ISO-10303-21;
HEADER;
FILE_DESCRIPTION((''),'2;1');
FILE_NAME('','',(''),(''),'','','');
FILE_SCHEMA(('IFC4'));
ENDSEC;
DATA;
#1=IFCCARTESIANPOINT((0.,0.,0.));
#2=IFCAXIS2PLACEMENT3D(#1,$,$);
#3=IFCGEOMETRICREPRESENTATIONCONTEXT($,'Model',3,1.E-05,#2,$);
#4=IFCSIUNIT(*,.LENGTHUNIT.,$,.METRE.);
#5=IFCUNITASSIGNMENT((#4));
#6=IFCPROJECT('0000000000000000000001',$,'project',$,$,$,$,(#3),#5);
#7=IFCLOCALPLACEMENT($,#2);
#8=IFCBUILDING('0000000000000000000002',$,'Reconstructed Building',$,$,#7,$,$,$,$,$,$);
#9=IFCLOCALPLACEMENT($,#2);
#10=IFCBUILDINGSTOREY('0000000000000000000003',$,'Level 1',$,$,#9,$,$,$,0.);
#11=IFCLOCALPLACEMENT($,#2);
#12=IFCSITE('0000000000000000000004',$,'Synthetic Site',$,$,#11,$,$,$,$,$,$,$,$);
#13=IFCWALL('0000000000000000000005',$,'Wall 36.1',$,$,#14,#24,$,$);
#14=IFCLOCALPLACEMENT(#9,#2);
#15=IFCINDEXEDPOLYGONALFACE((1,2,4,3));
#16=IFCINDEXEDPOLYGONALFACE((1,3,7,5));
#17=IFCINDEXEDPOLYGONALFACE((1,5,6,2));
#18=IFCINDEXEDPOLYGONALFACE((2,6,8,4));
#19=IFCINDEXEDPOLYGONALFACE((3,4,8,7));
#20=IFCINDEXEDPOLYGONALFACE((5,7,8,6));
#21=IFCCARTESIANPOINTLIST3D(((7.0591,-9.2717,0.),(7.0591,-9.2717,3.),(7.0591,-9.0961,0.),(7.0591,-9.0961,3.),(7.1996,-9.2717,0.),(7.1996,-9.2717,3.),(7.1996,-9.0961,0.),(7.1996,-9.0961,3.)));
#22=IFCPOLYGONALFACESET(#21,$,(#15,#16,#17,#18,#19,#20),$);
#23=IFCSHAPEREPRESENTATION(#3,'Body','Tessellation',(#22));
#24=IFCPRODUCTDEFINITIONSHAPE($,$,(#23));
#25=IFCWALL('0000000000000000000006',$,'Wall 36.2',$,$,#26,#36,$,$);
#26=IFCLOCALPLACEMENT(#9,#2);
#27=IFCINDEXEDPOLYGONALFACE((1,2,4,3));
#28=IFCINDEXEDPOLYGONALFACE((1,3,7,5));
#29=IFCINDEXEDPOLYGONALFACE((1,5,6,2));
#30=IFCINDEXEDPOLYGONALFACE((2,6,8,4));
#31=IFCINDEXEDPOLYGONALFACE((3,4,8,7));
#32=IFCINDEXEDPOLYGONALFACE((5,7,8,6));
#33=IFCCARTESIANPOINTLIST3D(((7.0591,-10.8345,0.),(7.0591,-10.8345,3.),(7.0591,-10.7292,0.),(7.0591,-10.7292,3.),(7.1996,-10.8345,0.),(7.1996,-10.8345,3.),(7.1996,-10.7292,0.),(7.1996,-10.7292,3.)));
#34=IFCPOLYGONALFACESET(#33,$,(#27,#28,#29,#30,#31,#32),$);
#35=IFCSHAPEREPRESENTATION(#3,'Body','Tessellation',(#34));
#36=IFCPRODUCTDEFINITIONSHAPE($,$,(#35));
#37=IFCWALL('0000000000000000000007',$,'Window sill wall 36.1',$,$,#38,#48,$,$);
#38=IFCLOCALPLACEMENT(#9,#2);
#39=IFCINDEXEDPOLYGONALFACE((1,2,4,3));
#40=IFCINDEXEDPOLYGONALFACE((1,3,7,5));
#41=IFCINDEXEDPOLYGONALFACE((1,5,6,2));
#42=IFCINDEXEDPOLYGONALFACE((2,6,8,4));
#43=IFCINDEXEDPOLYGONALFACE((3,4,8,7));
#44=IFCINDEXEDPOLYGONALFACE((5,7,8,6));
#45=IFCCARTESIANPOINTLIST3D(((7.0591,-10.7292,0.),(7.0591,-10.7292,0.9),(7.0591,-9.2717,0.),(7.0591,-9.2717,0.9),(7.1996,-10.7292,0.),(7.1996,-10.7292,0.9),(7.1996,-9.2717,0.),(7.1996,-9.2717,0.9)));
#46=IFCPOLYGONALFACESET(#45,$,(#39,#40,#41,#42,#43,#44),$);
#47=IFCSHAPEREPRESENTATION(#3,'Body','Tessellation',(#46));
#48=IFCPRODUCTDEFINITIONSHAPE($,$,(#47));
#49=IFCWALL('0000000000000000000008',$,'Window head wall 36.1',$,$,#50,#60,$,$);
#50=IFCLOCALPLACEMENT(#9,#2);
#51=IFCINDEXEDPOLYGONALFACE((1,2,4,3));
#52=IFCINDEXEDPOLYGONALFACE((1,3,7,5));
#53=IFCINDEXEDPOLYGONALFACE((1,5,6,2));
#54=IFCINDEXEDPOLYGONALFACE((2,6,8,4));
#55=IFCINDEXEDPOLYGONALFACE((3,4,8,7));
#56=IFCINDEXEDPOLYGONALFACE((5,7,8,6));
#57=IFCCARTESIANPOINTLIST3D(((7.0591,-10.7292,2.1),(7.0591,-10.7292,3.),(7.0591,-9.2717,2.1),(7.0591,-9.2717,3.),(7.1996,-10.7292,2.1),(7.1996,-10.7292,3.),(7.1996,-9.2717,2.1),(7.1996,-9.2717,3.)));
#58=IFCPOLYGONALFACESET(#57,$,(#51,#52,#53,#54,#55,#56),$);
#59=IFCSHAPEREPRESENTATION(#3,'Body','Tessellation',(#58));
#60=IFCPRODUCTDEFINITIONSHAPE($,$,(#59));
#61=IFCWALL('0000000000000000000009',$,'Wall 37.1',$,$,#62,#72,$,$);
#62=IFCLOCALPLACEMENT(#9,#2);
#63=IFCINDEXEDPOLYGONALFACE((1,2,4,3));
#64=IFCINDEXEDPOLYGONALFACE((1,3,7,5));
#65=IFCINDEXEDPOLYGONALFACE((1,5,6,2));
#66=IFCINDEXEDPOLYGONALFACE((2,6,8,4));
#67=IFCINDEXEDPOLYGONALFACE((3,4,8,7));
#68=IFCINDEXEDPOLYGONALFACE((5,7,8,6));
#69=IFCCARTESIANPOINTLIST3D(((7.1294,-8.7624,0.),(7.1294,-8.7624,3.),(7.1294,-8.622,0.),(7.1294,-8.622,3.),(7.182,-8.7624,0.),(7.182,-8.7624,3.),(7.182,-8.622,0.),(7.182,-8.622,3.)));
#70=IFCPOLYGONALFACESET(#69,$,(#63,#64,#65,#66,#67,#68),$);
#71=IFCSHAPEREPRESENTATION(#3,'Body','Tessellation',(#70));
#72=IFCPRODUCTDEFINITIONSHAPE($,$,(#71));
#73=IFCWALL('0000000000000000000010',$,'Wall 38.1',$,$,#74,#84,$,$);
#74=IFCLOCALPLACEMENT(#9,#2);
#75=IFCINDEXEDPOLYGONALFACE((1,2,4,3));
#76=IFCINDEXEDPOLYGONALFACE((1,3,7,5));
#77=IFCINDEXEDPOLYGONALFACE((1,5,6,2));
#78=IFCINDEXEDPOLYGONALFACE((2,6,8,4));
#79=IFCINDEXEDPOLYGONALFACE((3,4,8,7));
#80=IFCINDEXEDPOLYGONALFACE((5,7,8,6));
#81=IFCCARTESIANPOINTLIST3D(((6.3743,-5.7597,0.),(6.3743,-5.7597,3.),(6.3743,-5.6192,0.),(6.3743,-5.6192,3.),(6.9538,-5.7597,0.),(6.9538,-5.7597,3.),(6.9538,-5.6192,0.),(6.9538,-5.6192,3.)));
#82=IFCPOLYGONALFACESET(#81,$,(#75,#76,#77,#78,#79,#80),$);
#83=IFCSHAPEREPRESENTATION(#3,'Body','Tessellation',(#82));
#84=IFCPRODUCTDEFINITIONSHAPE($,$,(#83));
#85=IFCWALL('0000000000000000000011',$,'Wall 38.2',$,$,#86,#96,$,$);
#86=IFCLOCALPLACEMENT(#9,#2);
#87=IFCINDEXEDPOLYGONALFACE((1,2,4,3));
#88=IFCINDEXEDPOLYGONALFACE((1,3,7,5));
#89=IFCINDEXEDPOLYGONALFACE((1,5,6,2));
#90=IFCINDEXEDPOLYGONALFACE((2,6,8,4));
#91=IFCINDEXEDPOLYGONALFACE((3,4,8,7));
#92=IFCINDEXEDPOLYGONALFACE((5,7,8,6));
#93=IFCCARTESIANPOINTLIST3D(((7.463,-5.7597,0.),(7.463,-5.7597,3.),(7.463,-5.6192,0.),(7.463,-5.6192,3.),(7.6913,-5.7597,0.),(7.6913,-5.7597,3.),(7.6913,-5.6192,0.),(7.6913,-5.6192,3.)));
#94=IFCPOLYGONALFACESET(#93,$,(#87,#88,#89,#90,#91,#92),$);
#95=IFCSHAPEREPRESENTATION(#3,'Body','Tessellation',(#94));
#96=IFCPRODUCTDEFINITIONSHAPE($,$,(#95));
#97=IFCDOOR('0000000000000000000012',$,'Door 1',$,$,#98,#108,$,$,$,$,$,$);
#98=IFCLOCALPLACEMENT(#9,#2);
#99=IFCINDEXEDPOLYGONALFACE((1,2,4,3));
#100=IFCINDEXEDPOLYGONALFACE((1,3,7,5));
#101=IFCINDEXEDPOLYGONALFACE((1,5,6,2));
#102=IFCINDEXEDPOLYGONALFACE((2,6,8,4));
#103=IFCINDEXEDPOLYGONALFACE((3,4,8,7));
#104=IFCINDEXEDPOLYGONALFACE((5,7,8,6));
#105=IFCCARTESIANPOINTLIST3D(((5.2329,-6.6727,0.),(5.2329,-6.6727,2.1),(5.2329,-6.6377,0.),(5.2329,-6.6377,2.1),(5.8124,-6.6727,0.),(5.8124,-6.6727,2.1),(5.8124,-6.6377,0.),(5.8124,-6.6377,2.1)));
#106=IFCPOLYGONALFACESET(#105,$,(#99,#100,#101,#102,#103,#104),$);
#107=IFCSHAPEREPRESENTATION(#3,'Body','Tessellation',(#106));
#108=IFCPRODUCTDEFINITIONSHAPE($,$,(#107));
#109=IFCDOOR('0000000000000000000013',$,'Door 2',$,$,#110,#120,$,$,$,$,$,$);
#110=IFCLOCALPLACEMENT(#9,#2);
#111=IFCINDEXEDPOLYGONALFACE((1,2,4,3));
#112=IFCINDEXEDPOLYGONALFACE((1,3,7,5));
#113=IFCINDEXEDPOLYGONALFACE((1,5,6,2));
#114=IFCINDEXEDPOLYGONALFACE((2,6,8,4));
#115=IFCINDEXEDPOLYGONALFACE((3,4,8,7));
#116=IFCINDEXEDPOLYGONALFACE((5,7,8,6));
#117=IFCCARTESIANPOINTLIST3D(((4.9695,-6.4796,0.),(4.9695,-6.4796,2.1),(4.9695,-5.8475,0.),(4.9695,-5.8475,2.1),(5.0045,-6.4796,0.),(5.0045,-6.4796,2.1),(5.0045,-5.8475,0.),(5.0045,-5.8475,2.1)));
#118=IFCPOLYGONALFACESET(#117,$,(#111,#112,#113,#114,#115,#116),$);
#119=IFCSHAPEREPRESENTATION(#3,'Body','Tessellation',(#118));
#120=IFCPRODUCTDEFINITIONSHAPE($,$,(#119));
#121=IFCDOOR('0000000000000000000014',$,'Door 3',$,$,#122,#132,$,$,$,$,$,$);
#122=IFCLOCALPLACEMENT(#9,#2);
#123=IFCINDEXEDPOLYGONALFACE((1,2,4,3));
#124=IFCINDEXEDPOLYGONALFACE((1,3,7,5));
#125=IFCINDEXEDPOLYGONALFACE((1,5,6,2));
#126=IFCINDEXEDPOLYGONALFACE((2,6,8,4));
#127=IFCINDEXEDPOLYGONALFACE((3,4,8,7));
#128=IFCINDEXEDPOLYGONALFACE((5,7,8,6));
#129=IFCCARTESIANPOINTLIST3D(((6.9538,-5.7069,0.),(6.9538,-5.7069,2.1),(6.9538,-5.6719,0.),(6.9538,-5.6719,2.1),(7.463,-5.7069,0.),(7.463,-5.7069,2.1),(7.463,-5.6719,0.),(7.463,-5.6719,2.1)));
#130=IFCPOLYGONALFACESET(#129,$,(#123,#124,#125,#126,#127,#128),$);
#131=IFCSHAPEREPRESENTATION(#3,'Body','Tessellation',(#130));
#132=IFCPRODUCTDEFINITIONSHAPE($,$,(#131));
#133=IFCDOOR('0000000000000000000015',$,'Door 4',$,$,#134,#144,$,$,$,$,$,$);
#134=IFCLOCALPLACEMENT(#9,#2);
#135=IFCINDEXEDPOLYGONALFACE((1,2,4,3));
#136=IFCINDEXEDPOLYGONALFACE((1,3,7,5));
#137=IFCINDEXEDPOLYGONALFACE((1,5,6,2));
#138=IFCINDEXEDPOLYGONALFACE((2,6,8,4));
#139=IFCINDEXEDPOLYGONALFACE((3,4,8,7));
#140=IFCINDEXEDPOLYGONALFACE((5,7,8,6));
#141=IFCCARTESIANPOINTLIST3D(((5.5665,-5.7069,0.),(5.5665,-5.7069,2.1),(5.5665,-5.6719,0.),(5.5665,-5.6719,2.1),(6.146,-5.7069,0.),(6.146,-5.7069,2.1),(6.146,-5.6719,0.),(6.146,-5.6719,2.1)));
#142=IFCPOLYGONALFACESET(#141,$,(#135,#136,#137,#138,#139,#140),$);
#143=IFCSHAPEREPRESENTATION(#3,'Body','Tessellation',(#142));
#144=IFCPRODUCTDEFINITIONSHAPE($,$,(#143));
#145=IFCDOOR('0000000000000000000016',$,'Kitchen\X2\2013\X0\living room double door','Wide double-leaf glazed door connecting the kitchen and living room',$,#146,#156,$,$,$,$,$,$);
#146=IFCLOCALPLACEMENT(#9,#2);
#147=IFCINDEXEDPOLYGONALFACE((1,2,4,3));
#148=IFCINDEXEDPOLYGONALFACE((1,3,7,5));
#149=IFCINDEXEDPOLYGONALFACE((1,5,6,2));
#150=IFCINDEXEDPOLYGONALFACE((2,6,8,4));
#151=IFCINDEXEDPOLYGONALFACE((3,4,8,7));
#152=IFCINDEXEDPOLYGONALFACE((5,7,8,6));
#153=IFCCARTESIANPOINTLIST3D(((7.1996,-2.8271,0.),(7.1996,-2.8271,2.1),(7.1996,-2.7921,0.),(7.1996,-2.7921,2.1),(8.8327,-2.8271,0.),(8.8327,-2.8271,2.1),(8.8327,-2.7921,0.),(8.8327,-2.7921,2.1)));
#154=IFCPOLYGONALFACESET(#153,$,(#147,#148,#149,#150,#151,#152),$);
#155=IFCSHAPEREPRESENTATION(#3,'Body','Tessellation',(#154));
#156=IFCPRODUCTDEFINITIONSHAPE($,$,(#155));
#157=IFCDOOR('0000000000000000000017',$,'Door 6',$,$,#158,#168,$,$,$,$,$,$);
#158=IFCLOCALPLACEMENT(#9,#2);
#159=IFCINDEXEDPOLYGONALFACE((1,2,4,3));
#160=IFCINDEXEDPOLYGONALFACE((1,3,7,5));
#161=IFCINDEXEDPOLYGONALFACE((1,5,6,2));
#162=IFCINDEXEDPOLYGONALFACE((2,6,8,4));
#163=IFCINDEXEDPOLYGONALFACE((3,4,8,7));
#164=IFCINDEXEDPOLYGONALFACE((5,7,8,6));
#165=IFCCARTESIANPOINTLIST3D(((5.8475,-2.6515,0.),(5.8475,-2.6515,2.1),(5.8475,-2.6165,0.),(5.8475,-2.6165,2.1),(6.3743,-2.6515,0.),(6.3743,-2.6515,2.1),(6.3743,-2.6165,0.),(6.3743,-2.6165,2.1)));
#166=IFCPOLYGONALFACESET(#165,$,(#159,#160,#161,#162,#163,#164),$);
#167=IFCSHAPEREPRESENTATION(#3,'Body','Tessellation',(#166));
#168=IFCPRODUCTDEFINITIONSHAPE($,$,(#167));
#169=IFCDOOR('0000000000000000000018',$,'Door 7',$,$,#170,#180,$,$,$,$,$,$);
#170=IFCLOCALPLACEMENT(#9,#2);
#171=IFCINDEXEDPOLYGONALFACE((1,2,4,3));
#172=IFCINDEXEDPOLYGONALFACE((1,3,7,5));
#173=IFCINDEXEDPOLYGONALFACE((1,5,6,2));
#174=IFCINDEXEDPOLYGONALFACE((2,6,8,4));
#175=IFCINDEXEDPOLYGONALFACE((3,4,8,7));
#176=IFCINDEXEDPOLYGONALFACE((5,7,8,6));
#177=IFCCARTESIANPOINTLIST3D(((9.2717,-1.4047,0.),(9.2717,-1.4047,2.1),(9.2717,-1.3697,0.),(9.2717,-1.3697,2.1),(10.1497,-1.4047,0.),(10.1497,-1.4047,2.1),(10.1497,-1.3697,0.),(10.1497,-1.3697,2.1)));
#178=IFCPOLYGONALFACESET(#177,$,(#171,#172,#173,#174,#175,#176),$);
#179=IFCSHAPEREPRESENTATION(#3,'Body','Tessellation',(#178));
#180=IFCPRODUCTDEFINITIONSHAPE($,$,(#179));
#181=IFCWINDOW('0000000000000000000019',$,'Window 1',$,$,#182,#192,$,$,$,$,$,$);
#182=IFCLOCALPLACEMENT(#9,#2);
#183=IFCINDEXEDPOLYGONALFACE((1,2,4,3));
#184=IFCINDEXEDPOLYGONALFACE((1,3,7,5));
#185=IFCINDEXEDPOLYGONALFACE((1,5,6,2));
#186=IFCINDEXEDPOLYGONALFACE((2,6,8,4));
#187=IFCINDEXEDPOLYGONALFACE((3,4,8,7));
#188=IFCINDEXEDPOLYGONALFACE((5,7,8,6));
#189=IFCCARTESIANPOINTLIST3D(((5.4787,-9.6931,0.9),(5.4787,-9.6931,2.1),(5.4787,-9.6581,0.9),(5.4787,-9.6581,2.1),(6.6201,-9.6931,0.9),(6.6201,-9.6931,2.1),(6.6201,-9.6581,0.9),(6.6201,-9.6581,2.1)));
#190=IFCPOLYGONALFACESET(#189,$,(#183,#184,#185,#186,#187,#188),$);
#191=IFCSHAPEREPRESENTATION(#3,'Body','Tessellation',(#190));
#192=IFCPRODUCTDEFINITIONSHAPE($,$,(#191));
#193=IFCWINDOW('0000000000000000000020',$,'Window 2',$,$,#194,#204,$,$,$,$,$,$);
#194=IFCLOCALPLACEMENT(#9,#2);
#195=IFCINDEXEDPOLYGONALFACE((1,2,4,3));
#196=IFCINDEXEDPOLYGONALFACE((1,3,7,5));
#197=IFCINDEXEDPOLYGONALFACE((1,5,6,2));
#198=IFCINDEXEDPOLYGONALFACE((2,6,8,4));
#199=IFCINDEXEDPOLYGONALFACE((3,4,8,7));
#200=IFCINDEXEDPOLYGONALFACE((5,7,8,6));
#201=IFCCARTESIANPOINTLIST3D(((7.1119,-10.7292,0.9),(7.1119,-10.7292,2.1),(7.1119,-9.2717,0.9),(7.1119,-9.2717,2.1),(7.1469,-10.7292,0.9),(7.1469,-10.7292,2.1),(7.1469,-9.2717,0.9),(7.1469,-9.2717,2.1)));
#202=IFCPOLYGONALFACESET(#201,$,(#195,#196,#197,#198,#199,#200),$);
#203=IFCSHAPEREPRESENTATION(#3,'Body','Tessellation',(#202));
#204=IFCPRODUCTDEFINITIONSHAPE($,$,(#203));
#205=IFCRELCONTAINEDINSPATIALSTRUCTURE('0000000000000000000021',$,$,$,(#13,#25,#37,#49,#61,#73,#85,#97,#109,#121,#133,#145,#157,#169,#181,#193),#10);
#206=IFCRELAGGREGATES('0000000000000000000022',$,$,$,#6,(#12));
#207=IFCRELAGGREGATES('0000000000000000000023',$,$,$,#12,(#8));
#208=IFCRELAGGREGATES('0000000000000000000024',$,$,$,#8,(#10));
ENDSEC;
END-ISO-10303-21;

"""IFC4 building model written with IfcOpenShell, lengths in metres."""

from ifc_helpers import new_model, si_unit, frame, origin, place, context, project, spatial, polyline, outline, extrude, element, save


model = new_model("IFC4")

# Units and contexts
model_context = context("Model", 3, precision=1e-05, world=origin())
ifc_project = project(units=[si_unit("LENGTHUNIT", "METRE")], contexts=[model_context])

# Site, building, storey
site_placement = place(None, origin())
site = spatial("IfcSite", under=ifc_project, at=site_placement, Name="Synthetic Site")
building_placement = place(None, origin())
building = spatial("IfcBuilding", under=site, at=building_placement, Name="Reconstructed Building")
storey_placement = place(None, origin())
storey = spatial("IfcBuildingStorey", under=building, at=storey_placement, Name="Level 1", Elevation=0.0)

# Walls
wall_1_placement = place(None, origin())
element("IfcWall", 1, at=wall_1_placement, inside=storey, Name="Wall 36.1", context=model_context, shape_type="SweptSolid", body=[
    extrude(outline(polyline([(7.0591, -9.0961), (7.0591, -9.2717), (7.1996, -9.2717), (7.1996, -9.0961), (7.0591, -9.0961)])), frame((0.0, 0.0, 0.0), z_axis=(0.0, 0.0, 1.0)), (0.0, 0.0, 1.0), 3.0),
])
wall_2_placement = place(None, origin())
element("IfcWall", 2, at=wall_2_placement, inside=storey, Name="Wall 36.2", context=model_context, shape_type="SweptSolid", body=[
    extrude(outline(polyline([(7.0591, -10.7292), (7.0591, -10.8345), (7.1996, -10.8345), (7.1996, -10.7292), (7.0591, -10.7292)])), frame((0.0, 0.0, 0.0), z_axis=(0.0, 0.0, 1.0)), (0.0, 0.0, 1.0), 3.0),
])
wall_3_placement = place(None, origin())
element("IfcWall", 3, at=wall_3_placement, inside=storey, Name="Window sill wall 36.1", context=model_context, shape_type="SweptSolid", body=[
    extrude(outline(polyline([(7.0591, -9.2717), (7.0591, -10.7292), (7.1996, -10.7292), (7.1996, -9.2717), (7.0591, -9.2717)])), frame((0.0, 0.0, 0.0), z_axis=(0.0, 0.0, 1.0)), (0.0, 0.0, 1.0), 0.9),
])
wall_4_placement = place(None, origin())
element("IfcWall", 4, at=wall_4_placement, inside=storey, Name="Window head wall 36.1", context=model_context, shape_type="SweptSolid", body=[
    extrude(outline(polyline([(7.0591, -9.2717), (7.0591, -10.7292), (7.1996, -10.7292), (7.1996, -9.2717), (7.0591, -9.2717)])), frame((0.0, 0.0, 2.1), z_axis=(0.0, 0.0, 1.0)), (0.0, 0.0, 1.0), 0.9),
])
wall_5_placement = place(None, origin())
element("IfcWall", 5, at=wall_5_placement, inside=storey, Name="Wall 37.1", context=model_context, shape_type="SweptSolid", body=[
    extrude(outline(polyline([(7.1294, -8.7624), (7.182, -8.7624), (7.182, -8.622), (7.1294, -8.622), (7.1294, -8.7624)])), frame((0.0, 0.0, 0.0), z_axis=(0.0, 0.0, 1.0)), (0.0, 0.0, 1.0), 3.0),
])
wall_6_placement = place(None, origin())
element("IfcWall", 6, at=wall_6_placement, inside=storey, Name="Wall 38.1", context=model_context, shape_type="SweptSolid", body=[
    extrude(outline(polyline([(6.3743, -5.7597), (6.9538, -5.7597), (6.9538, -5.6192), (6.3743, -5.6192), (6.3743, -5.7597)])), frame((0.0, 0.0, 0.0), z_axis=(0.0, 0.0, 1.0)), (0.0, 0.0, 1.0), 3.0),
])
wall_7_placement = place(None, origin())
element("IfcWall", 7, at=wall_7_placement, inside=storey, Name="Wall 38.2", context=model_context, shape_type="SweptSolid", body=[
    extrude(outline(polyline([(7.463, -5.7597), (7.6913, -5.7597), (7.6913, -5.6192), (7.463, -5.6192), (7.463, -5.7597)])), frame((0.0, 0.0, 0.0), z_axis=(0.0, 0.0, 1.0)), (0.0, 0.0, 1.0), 3.0),
])

# Doors
door_1_placement = place(None, origin())
element("IfcDoor", 8, at=door_1_placement, inside=storey, Name="Door 1", context=model_context, shape_type="SweptSolid", body=[
    extrude(outline(polyline([(5.2329, -6.6727), (5.8124, -6.6727), (5.8124, -6.6377), (5.2329, -6.6377), (5.2329, -6.6727)])), frame((0.0, 0.0, 0.0), z_axis=(0.0, 0.0, 1.0)), (0.0, 0.0, 1.0), 2.1),
])
door_2_placement = place(None, origin())
element("IfcDoor", 9, at=door_2_placement, inside=storey, Name="Door 2", context=model_context, shape_type="SweptSolid", body=[
    extrude(outline(polyline([(5.0045, -6.4796), (5.0045, -5.8475), (4.9695, -5.8475), (4.9695, -6.4796), (5.0045, -6.4796)])), frame((0.0, 0.0, 0.0), z_axis=(0.0, 0.0, 1.0)), (0.0, 0.0, 1.0), 2.1),
])
door_3_placement = place(None, origin())
element("IfcDoor", 10, at=door_3_placement, inside=storey, Name="Door 3", context=model_context, shape_type="SweptSolid", body=[
    extrude(outline(polyline([(6.9538, -5.7069), (7.463, -5.7069), (7.463, -5.6719), (6.9538, -5.6719), (6.9538, -5.7069)])), frame((0.0, 0.0, 0.0), z_axis=(0.0, 0.0, 1.0)), (0.0, 0.0, 1.0), 2.1),
])
door_4_placement = place(None, origin())
element("IfcDoor", 11, at=door_4_placement, inside=storey, Name="Door 4", context=model_context, shape_type="SweptSolid", body=[
    extrude(outline(polyline([(5.5665, -5.7069), (6.146, -5.7069), (6.146, -5.6719), (5.5665, -5.6719), (5.5665, -5.7069)])), frame((0.0, 0.0, 0.0), z_axis=(0.0, 0.0, 1.0)), (0.0, 0.0, 1.0), 2.1),
])
door_5_placement = place(None, origin())
element("IfcDoor", 12, at=door_5_placement, inside=storey, Name="Kitchen–living room double door", Description="Wide double-leaf glazed door connecting the kitchen and living room", context=model_context, shape_type="SweptSolid", body=[
    extrude(outline(polyline([(8.8327, -2.7921), (7.1996, -2.7921), (7.1996, -2.8271), (8.8327, -2.8271), (8.8327, -2.7921)])), frame((0.0, 0.0, 0.0), z_axis=(0.0, 0.0, 1.0)), (0.0, 0.0, 1.0), 2.1),
])
door_6_placement = place(None, origin())
element("IfcDoor", 13, at=door_6_placement, inside=storey, Name="Door 6", context=model_context, shape_type="SweptSolid", body=[
    extrude(outline(polyline([(5.8475, -2.6515), (6.3743, -2.6515), (6.3743, -2.6165), (5.8475, -2.6165), (5.8475, -2.6515)])), frame((0.0, 0.0, 0.0), z_axis=(0.0, 0.0, 1.0)), (0.0, 0.0, 1.0), 2.1),
])
door_7_placement = place(None, origin())
element("IfcDoor", 14, at=door_7_placement, inside=storey, Name="Door 7", context=model_context, shape_type="SweptSolid", body=[
    extrude(outline(polyline([(9.2717, -1.4047), (10.1497, -1.4047), (10.1497, -1.3697), (9.2717, -1.3697), (9.2717, -1.4047)])), frame((0.0, 0.0, 0.0), z_axis=(0.0, 0.0, 1.0)), (0.0, 0.0, 1.0), 2.1),
])

# Windows
window_1_placement = place(None, origin())
element("IfcWindow", 15, at=window_1_placement, inside=storey, Name="Window 1", context=model_context, shape_type="SweptSolid", body=[
    extrude(outline(polyline([(5.4787, -9.6931), (6.6201, -9.6931), (6.6201, -9.6581), (5.4787, -9.6581), (5.4787, -9.6931)])), frame((0.0, 0.0, 0.9), z_axis=(0.0, 0.0, 1.0)), (0.0, 0.0, 1.0), 1.2),
])
window_2_placement = place(None, origin())
element("IfcWindow", 16, at=window_2_placement, inside=storey, Name="Window 2", context=model_context, shape_type="SweptSolid", body=[
    extrude(outline(polyline([(7.1119, -9.2717), (7.1119, -10.7292), (7.1469, -10.7292), (7.1469, -9.2717), (7.1119, -9.2717)])), frame((0.0, 0.0, 0.9), z_axis=(0.0, 0.0, 1.0)), (0.0, 0.0, 1.0), 1.2),
])

save(model, "model.ifc")
